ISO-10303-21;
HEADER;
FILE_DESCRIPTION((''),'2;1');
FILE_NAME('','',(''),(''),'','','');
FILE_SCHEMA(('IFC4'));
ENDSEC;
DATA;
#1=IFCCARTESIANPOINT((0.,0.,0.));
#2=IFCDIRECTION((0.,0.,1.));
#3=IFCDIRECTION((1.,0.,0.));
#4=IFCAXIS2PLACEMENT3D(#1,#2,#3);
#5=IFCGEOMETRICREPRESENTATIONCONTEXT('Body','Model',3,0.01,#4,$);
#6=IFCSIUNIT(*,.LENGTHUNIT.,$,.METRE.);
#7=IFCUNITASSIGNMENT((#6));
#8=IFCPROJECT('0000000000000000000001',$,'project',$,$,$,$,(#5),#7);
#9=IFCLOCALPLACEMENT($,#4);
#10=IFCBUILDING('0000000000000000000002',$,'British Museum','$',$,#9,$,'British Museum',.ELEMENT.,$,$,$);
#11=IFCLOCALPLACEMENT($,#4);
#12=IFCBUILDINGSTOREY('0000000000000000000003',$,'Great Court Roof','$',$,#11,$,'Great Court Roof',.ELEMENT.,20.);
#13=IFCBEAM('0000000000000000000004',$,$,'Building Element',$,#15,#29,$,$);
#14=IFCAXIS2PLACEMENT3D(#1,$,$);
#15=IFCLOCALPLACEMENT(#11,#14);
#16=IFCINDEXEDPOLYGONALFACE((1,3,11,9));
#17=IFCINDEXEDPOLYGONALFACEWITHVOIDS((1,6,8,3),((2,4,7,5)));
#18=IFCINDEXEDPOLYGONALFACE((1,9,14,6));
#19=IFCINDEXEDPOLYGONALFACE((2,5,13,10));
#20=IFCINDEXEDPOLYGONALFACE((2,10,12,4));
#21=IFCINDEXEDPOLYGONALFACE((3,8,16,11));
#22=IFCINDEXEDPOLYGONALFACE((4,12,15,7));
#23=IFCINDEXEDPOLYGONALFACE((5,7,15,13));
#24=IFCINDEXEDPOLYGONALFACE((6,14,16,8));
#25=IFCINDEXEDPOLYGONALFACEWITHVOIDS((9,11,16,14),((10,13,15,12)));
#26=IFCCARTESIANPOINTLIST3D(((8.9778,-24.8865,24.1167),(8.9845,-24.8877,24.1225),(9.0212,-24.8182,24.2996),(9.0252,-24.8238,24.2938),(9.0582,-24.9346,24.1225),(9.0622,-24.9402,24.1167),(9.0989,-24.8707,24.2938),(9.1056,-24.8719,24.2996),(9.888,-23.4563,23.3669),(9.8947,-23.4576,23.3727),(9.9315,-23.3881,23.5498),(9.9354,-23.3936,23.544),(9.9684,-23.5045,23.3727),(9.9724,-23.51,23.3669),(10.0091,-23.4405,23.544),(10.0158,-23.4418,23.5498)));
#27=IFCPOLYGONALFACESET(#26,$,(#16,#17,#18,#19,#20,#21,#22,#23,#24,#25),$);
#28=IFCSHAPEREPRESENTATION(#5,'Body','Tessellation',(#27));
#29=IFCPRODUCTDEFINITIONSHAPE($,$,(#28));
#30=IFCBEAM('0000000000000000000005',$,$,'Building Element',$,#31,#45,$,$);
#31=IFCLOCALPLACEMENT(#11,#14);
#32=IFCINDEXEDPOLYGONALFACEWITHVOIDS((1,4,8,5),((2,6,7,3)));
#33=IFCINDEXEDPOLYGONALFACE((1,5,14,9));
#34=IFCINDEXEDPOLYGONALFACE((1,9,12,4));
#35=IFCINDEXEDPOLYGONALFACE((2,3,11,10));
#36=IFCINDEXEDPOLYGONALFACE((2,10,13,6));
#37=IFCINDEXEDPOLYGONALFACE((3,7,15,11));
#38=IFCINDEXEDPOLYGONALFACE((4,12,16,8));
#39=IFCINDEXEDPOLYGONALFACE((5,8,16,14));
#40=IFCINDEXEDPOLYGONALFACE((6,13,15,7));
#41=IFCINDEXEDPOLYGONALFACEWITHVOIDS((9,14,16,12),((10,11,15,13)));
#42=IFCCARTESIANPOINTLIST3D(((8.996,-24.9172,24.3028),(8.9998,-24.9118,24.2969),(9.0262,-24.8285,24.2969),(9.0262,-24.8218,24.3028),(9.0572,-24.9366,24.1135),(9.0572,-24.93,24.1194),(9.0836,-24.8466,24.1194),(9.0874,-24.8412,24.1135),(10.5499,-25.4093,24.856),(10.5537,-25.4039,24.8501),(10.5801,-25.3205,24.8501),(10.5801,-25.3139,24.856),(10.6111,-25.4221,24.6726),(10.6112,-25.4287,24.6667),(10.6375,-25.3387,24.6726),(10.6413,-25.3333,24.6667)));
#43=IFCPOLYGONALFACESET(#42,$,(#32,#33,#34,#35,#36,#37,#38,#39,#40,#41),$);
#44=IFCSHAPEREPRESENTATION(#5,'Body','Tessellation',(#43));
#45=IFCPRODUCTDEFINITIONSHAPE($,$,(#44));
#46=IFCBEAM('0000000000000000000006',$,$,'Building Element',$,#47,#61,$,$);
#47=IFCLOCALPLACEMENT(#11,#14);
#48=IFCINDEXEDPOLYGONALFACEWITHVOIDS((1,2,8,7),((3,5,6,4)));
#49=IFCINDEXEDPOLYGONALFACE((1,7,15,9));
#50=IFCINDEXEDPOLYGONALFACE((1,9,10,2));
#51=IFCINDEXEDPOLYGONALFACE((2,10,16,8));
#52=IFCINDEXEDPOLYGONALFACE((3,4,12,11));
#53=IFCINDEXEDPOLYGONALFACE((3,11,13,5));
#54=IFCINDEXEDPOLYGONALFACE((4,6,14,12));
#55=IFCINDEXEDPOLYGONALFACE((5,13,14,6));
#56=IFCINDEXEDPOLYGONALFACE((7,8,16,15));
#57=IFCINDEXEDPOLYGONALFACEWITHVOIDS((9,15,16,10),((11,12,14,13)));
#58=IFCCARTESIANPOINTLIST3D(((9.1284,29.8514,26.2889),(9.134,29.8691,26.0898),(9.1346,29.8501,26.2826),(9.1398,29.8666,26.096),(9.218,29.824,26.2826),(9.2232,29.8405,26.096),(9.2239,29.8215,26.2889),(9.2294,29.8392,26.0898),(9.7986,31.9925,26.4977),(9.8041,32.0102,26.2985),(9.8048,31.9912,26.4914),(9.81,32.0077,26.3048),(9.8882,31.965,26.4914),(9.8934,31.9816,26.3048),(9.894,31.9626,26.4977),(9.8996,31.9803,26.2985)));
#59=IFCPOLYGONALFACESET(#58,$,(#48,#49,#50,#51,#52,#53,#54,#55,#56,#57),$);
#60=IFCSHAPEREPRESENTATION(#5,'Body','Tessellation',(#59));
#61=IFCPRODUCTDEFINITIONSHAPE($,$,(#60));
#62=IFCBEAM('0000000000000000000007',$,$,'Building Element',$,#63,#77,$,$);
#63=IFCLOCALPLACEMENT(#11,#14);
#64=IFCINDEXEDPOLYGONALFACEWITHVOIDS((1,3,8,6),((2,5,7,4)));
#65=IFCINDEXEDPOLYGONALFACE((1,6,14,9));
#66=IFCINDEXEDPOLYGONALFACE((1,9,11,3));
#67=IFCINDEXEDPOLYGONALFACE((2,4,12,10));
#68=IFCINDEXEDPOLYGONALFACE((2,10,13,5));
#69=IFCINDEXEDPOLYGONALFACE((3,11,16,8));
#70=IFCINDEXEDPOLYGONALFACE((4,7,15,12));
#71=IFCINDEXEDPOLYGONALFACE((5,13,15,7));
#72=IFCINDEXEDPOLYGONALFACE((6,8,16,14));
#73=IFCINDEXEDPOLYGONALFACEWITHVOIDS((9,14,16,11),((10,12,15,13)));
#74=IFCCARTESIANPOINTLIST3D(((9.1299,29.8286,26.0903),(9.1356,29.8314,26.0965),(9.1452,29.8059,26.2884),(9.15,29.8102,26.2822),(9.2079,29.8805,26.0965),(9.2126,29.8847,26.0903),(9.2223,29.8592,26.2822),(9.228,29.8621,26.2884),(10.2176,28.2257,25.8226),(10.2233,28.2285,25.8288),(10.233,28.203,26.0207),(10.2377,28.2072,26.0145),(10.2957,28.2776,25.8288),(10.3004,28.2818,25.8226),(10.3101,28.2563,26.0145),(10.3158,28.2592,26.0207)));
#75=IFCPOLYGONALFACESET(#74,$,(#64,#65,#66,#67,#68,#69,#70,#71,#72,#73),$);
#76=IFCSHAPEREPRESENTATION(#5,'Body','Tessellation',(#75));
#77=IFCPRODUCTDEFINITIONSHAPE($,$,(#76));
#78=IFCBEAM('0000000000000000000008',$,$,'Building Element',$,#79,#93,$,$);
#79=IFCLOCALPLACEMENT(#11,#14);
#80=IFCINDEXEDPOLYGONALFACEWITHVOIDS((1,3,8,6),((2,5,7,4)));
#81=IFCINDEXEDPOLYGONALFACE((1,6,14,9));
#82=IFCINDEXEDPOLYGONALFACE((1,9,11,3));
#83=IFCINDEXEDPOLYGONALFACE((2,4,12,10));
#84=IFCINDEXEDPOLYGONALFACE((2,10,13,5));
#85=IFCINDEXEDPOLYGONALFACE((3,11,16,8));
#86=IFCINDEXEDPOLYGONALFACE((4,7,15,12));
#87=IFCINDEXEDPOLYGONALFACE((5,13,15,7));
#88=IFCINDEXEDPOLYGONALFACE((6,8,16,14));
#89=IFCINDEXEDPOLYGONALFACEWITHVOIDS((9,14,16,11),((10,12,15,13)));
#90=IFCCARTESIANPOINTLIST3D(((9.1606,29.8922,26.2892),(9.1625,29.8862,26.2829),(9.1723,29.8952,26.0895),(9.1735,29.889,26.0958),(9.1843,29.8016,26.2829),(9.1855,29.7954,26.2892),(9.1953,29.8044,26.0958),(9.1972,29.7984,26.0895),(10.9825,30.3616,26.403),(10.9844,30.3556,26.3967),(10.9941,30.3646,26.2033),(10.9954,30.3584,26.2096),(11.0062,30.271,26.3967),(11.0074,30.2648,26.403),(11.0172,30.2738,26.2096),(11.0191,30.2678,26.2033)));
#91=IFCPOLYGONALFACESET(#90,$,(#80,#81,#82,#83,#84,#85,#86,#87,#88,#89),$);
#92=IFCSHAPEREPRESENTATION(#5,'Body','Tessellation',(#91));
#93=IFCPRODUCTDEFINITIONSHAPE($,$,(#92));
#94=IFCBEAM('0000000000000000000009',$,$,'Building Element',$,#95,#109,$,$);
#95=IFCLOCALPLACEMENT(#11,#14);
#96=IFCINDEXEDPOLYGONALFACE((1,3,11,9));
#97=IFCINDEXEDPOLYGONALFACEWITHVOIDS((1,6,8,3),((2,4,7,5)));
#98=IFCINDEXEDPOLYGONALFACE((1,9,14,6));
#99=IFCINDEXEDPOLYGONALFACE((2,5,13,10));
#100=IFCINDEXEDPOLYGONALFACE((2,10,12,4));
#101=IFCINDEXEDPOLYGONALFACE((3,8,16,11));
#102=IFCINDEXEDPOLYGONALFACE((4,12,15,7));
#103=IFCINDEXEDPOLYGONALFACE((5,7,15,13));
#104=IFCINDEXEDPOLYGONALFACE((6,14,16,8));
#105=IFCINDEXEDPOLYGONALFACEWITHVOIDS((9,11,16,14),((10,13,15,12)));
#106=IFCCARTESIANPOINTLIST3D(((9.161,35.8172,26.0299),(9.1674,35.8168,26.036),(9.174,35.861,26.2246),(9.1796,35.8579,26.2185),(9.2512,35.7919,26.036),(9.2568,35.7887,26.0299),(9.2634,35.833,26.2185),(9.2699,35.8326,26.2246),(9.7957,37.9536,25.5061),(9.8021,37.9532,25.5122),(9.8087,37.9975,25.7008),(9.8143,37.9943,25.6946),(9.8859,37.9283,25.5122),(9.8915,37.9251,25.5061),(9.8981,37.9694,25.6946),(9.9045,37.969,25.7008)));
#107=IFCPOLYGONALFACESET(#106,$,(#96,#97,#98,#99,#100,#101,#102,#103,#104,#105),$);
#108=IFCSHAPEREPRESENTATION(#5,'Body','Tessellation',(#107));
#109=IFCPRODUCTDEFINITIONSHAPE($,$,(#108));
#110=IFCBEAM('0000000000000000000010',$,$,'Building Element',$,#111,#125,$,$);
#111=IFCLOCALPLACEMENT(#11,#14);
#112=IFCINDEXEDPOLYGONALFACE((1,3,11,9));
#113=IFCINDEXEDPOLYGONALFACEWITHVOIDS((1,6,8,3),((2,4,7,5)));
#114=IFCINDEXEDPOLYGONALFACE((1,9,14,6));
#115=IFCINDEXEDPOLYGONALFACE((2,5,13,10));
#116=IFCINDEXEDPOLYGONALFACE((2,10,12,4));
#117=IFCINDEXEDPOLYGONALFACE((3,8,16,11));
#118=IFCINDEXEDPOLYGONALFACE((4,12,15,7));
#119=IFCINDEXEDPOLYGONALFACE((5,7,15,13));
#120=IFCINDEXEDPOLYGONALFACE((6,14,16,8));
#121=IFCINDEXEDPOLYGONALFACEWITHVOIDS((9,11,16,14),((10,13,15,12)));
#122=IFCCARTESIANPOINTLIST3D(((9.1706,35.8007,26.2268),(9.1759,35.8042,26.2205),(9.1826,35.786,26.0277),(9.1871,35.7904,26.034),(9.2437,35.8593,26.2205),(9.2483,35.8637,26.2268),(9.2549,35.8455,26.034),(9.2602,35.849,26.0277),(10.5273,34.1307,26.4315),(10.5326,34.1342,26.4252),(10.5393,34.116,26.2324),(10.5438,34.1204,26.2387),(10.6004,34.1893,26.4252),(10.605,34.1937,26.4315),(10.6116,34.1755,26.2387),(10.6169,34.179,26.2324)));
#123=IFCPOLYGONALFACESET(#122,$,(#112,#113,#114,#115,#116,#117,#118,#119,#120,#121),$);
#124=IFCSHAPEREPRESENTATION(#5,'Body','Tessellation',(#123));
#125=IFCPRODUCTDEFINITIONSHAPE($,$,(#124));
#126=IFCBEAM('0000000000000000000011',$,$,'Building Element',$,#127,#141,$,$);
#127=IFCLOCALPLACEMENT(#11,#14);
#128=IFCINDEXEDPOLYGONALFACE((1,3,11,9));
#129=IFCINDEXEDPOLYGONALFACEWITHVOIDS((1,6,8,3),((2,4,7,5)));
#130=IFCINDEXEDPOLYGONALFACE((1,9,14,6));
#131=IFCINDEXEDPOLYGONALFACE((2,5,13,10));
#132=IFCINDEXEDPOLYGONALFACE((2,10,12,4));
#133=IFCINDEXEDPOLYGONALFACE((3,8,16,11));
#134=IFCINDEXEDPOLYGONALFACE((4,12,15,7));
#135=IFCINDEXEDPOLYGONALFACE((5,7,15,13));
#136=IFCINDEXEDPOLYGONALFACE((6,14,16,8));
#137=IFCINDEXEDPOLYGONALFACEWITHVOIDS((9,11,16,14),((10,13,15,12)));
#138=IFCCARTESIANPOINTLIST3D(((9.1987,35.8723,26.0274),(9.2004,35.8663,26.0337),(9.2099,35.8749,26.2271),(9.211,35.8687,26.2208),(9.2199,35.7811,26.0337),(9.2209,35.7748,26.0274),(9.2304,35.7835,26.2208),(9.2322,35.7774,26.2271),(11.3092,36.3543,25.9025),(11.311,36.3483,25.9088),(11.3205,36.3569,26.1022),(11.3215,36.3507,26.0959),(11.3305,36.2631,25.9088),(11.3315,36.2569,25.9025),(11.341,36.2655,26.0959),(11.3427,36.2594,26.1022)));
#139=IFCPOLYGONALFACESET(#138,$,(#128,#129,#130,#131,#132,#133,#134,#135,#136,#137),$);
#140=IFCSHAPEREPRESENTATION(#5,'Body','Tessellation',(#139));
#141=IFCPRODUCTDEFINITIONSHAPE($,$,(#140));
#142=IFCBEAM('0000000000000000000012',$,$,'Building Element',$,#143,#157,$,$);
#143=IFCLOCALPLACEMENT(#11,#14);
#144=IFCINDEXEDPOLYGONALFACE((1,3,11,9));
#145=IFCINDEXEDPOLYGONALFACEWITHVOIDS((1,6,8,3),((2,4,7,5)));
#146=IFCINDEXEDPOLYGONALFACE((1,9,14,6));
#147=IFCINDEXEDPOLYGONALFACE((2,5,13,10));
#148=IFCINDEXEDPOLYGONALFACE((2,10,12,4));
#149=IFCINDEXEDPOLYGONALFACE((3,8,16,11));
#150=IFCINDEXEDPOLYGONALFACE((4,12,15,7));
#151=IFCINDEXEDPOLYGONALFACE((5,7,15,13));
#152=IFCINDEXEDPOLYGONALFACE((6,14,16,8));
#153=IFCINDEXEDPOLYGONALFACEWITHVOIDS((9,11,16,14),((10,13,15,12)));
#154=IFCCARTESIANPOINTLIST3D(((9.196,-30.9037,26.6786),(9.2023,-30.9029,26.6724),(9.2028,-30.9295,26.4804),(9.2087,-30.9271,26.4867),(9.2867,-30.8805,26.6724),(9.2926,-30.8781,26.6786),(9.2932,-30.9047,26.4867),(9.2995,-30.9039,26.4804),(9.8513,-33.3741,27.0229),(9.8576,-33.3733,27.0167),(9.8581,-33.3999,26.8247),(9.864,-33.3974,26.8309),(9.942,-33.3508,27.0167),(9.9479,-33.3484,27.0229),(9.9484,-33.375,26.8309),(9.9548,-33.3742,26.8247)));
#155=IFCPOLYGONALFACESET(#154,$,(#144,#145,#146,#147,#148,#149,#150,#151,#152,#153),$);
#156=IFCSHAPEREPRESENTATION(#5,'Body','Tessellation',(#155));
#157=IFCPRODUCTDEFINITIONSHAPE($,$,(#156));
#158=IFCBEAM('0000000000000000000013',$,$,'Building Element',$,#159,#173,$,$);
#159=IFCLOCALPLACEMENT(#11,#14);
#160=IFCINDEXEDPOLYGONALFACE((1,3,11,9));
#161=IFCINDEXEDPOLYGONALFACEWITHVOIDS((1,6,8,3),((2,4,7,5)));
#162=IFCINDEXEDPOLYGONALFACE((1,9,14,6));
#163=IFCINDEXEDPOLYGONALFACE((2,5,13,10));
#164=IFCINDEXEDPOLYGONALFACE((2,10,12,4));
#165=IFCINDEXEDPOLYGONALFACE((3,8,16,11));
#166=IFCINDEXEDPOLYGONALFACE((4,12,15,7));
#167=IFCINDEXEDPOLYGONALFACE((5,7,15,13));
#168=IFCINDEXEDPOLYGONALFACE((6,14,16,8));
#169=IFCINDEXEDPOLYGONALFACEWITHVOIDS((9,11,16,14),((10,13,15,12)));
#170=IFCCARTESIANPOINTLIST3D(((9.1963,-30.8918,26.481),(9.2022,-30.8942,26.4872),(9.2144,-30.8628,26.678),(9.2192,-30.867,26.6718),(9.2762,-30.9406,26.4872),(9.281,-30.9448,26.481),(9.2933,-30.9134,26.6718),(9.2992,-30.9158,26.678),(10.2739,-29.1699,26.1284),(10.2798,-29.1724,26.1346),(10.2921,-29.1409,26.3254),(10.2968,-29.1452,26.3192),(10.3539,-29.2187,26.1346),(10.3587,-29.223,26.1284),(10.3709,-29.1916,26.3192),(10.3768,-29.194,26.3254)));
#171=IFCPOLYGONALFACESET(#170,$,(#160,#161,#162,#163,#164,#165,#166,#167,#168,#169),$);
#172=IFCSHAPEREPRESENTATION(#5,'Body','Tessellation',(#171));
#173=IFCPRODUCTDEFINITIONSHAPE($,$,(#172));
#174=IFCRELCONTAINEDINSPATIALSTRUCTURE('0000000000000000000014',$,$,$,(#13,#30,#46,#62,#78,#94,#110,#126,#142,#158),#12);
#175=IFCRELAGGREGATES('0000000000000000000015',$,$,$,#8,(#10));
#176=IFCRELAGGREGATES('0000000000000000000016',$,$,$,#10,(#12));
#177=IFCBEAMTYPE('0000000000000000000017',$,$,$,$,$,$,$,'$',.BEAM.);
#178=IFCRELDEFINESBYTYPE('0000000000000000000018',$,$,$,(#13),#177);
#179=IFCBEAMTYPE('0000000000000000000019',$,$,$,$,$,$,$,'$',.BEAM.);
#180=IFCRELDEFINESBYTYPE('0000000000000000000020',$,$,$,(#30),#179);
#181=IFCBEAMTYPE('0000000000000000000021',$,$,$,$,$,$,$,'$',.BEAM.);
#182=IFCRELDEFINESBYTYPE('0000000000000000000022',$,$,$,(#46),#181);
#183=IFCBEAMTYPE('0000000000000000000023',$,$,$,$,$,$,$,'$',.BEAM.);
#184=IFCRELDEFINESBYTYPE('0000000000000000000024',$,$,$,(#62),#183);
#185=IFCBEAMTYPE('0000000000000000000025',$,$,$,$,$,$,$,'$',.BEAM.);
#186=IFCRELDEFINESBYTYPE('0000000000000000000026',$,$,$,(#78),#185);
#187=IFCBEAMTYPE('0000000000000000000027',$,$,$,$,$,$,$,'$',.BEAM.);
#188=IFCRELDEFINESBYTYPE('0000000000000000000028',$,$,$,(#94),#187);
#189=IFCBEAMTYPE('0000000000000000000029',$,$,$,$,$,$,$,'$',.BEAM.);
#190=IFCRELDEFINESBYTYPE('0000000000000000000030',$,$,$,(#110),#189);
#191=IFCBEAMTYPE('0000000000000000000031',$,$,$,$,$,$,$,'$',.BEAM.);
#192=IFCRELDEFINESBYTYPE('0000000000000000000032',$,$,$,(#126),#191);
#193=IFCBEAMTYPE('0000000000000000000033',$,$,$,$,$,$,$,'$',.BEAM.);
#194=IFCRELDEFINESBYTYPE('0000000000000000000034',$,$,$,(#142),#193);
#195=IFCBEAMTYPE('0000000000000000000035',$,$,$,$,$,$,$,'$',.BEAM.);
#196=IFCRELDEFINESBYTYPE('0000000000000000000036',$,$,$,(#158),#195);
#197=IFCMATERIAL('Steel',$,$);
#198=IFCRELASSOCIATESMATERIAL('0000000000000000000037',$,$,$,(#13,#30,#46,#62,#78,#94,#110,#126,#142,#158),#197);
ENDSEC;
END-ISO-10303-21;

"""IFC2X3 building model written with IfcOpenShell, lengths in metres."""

from ifc_helpers import new_model, si_unit, frame, origin_with_axes, origin_2d, place, context, project, spatial, hollow_rectangle, extrude, material, type_object, element, save


model = new_model("IFC2X3")

# Units and contexts
model_context = context("Model", 3, precision=0.01, world=origin_with_axes(), identifier="Body")
ifc_project = project(units=[si_unit("LENGTHUNIT", "METRE")], contexts=[model_context])

# Building, storey
building_placement = place(None, origin_with_axes())
building = spatial("IfcBuilding", under=ifc_project, at=building_placement, Name="British Museum", Description="$", LongName="British Museum", CompositionType="ELEMENT")
storey_placement = place(None, origin_with_axes())
storey = spatial("IfcBuildingStorey", under=building, at=storey_placement, Name="Great Court Roof", Description="$", LongName="Great Court Roof", CompositionType="ELEMENT", Elevation=20.0)

# Beams
ifc_material = material(Name="Steel")
beam_type_1 = type_object("IfcBeamType", ElementType="$", PredefinedType="BEAM")
beam_1_placement = place(None, origin_with_axes())
element("IfcBeam", 1, at=beam_1_placement, inside=storey, type_object=beam_type_1, material=ifc_material, Description="Building Element", context=model_context, shape_type="SweptSolid", body=[
    extrude(hollow_rectangle(XDim=0.1, YDim=0.2, WallThickness=0.0063, InnerFilletRadius=0.0, OuterFilletRadius=0.0, at=origin_2d()), frame((9.0417, -24.8792, 24.2082), z_axis=(0.491046, 0.771529, -0.404495), x_axis=(-0.843626, 0.536932, 0.0)), (0.0, 0.0, 1.0), 1.8537),
])
beam_type_2 = type_object("IfcBeamType", ElementType="$", PredefinedType="BEAM")
beam_2_placement = place(None, origin_with_axes())
element("IfcBeam", 2, at=beam_2_placement, inside=storey, type_object=beam_type_2, material=ifc_material, Description="Building Element", context=model_context, shape_type="SweptSolid", body=[
    extrude(hollow_rectangle(XDim=0.1, YDim=0.2, WallThickness=0.0063, InnerFilletRadius=0.0, OuterFilletRadius=0.0, at=origin_2d()), frame((9.0417, -24.8792, 24.2082), z_axis=(0.902763, -0.285885, 0.321386), x_axis=(0.301901, 0.953339, 0.0)), (0.0, 0.0, 1.0), 1.7213),
])
beam_type_3 = type_object("IfcBeamType", ElementType="$", PredefinedType="BEAM")
beam_3_placement = place(None, origin_with_axes())
element("IfcBeam", 3, at=beam_3_placement, inside=storey, type_object=beam_type_3, material=ifc_material, Description="Building Element", context=model_context, shape_type="SweptSolid", body=[
    extrude(hollow_rectangle(XDim=0.1, YDim=0.2, WallThickness=0.0063, InnerFilletRadius=0.0, OuterFilletRadius=0.0, at=origin_2d()), frame((9.1789, 29.8453, 26.1893), z_axis=(0.297428, 0.950239, 0.092642), x_axis=(-0.954343, 0.298713, 0.0)), (0.0, 0.0, 1.0), 2.2532),
])
beam_type_4 = type_object("IfcBeamType", ElementType="$", PredefinedType="BEAM")
beam_4_placement = place(None, origin_with_axes())
element("IfcBeam", 4, at=beam_4_placement, inside=storey, type_object=beam_type_4, material=ifc_material, Description="Building Element", context=model_context, shape_type="SweptSolid", body=[
    extrude(hollow_rectangle(XDim=0.1, YDim=0.2, WallThickness=0.0063, InnerFilletRadius=0.0, OuterFilletRadius=0.0, at=origin_2d()), frame((9.1789, 29.8453, 26.1893), z_axis=(0.556248, -0.819663, -0.136897), x_axis=(0.827453, 0.561535, 0.0)), (0.0, 0.0, 1.0), 1.9556),
])
beam_type_5 = type_object("IfcBeamType", ElementType="$", PredefinedType="BEAM")
beam_5_placement = place(None, origin_with_axes())
element("IfcBeam", 5, at=beam_5_placement, inside=storey, type_object=beam_type_5, material=ifc_material, Description="Building Element", context=model_context, shape_type="SweptSolid", body=[
    extrude(hollow_rectangle(XDim=0.1, YDim=0.2, WallThickness=0.0063, InnerFilletRadius=0.0, OuterFilletRadius=0.0, at=origin_2d()), frame((9.1789, 29.8453, 26.1893), z_axis=(0.96661, 0.249037, 0.060378), x_axis=(-0.249493, 0.968377, 0.0)), (0.0, 0.0, 1.0), 1.8848),
])
beam_type_6 = type_object("IfcBeamType", ElementType="$", PredefinedType="BEAM")
beam_6_placement = place(None, origin_with_axes())
element("IfcBeam", 6, at=beam_6_placement, inside=storey, type_object=beam_type_6, material=ifc_material, Description="Building Element", context=model_context, shape_type="SweptSolid", body=[
    extrude(hollow_rectangle(XDim=0.1, YDim=0.2, WallThickness=0.0063, InnerFilletRadius=0.0, OuterFilletRadius=0.0, at=origin_2d()), frame((9.2154, 35.8249, 26.1272), z_axis=(0.277214, 0.93317, -0.228795), x_axis=(-0.958597, 0.284767, 0.0)), (0.0, 0.0, 1.0), 2.2895),
])
beam_type_7 = type_object("IfcBeamType", ElementType="$", PredefinedType="BEAM")
beam_7_placement = place(None, origin_with_axes())
element("IfcBeam", 7, at=beam_7_placement, inside=storey, type_object=beam_type_7, material=ifc_material, Description="Building Element", context=model_context, shape_type="SweptSolid", body=[
    extrude(hollow_rectangle(XDim=0.1, YDim=0.2, WallThickness=0.0063, InnerFilletRadius=0.0, OuterFilletRadius=0.0, at=origin_2d()), frame((9.2154, 35.8249, 26.1272), z_axis=(0.627708, -0.772665, 0.094716), x_axis=(0.776154, 0.630543, 0.0)), (0.0, 0.0, 1.0), 2.1614),
])
beam_type_8 = type_object("IfcBeamType", ElementType="$", PredefinedType="BEAM")
beam_8_placement = place(None, origin_with_axes())
element("IfcBeam", 8, at=beam_8_placement, inside=storey, type_object=beam_type_8, material=ifc_material, Description="Building Element", context=model_context, shape_type="SweptSolid", body=[
    extrude(hollow_rectangle(XDim=0.1, YDim=0.2, WallThickness=0.0063, InnerFilletRadius=0.0, OuterFilletRadius=0.0, at=origin_2d()), frame((9.2154, 35.8249, 26.1272), z_axis=(0.973281, 0.222281, -0.057579), x_axis=(-0.22265, 0.974898, 0.0)), (0.0, 0.0, 1.0), 2.1685),
])
beam_type_9 = type_object("IfcBeamType", ElementType="$", PredefinedType="BEAM")
beam_9_placement = place(None, origin_with_axes())
element("IfcBeam", 9, at=beam_9_placement, inside=storey, type_object=beam_type_9, material=ifc_material, Description="Building Element", context=model_context, shape_type="SweptSolid", body=[
    extrude(hollow_rectangle(XDim=0.1, YDim=0.2, WallThickness=0.0063, InnerFilletRadius=0.0, OuterFilletRadius=0.0, at=origin_2d()), frame((9.2477, -30.9038, 26.5795), z_axis=(0.254101, -0.95792, 0.133498), x_axis=(0.966572, 0.256396, 0.0)), (0.0, 0.0, 1.0), 2.5789),
])
beam_type_10 = type_object("IfcBeamType", ElementType="$", PredefinedType="BEAM")
beam_10_placement = place(None, origin_with_axes())
element("IfcBeam", 10, at=beam_10_placement, inside=storey, type_object=beam_type_10, material=ifc_material, Description="Building Element", context=model_context, shape_type="SweptSolid", body=[
    extrude(hollow_rectangle(XDim=0.1, YDim=0.2, WallThickness=0.0063, InnerFilletRadius=0.0, OuterFilletRadius=0.0, at=origin_2d()), frame((9.2477, -30.9038, 26.5795), z_axis=(0.522719, 0.835169, -0.171046), x_axis=(-0.847661, 0.530538, 0.0)), (0.0, 0.0, 1.0), 2.0616),
])

save(model, "model.ifc")
